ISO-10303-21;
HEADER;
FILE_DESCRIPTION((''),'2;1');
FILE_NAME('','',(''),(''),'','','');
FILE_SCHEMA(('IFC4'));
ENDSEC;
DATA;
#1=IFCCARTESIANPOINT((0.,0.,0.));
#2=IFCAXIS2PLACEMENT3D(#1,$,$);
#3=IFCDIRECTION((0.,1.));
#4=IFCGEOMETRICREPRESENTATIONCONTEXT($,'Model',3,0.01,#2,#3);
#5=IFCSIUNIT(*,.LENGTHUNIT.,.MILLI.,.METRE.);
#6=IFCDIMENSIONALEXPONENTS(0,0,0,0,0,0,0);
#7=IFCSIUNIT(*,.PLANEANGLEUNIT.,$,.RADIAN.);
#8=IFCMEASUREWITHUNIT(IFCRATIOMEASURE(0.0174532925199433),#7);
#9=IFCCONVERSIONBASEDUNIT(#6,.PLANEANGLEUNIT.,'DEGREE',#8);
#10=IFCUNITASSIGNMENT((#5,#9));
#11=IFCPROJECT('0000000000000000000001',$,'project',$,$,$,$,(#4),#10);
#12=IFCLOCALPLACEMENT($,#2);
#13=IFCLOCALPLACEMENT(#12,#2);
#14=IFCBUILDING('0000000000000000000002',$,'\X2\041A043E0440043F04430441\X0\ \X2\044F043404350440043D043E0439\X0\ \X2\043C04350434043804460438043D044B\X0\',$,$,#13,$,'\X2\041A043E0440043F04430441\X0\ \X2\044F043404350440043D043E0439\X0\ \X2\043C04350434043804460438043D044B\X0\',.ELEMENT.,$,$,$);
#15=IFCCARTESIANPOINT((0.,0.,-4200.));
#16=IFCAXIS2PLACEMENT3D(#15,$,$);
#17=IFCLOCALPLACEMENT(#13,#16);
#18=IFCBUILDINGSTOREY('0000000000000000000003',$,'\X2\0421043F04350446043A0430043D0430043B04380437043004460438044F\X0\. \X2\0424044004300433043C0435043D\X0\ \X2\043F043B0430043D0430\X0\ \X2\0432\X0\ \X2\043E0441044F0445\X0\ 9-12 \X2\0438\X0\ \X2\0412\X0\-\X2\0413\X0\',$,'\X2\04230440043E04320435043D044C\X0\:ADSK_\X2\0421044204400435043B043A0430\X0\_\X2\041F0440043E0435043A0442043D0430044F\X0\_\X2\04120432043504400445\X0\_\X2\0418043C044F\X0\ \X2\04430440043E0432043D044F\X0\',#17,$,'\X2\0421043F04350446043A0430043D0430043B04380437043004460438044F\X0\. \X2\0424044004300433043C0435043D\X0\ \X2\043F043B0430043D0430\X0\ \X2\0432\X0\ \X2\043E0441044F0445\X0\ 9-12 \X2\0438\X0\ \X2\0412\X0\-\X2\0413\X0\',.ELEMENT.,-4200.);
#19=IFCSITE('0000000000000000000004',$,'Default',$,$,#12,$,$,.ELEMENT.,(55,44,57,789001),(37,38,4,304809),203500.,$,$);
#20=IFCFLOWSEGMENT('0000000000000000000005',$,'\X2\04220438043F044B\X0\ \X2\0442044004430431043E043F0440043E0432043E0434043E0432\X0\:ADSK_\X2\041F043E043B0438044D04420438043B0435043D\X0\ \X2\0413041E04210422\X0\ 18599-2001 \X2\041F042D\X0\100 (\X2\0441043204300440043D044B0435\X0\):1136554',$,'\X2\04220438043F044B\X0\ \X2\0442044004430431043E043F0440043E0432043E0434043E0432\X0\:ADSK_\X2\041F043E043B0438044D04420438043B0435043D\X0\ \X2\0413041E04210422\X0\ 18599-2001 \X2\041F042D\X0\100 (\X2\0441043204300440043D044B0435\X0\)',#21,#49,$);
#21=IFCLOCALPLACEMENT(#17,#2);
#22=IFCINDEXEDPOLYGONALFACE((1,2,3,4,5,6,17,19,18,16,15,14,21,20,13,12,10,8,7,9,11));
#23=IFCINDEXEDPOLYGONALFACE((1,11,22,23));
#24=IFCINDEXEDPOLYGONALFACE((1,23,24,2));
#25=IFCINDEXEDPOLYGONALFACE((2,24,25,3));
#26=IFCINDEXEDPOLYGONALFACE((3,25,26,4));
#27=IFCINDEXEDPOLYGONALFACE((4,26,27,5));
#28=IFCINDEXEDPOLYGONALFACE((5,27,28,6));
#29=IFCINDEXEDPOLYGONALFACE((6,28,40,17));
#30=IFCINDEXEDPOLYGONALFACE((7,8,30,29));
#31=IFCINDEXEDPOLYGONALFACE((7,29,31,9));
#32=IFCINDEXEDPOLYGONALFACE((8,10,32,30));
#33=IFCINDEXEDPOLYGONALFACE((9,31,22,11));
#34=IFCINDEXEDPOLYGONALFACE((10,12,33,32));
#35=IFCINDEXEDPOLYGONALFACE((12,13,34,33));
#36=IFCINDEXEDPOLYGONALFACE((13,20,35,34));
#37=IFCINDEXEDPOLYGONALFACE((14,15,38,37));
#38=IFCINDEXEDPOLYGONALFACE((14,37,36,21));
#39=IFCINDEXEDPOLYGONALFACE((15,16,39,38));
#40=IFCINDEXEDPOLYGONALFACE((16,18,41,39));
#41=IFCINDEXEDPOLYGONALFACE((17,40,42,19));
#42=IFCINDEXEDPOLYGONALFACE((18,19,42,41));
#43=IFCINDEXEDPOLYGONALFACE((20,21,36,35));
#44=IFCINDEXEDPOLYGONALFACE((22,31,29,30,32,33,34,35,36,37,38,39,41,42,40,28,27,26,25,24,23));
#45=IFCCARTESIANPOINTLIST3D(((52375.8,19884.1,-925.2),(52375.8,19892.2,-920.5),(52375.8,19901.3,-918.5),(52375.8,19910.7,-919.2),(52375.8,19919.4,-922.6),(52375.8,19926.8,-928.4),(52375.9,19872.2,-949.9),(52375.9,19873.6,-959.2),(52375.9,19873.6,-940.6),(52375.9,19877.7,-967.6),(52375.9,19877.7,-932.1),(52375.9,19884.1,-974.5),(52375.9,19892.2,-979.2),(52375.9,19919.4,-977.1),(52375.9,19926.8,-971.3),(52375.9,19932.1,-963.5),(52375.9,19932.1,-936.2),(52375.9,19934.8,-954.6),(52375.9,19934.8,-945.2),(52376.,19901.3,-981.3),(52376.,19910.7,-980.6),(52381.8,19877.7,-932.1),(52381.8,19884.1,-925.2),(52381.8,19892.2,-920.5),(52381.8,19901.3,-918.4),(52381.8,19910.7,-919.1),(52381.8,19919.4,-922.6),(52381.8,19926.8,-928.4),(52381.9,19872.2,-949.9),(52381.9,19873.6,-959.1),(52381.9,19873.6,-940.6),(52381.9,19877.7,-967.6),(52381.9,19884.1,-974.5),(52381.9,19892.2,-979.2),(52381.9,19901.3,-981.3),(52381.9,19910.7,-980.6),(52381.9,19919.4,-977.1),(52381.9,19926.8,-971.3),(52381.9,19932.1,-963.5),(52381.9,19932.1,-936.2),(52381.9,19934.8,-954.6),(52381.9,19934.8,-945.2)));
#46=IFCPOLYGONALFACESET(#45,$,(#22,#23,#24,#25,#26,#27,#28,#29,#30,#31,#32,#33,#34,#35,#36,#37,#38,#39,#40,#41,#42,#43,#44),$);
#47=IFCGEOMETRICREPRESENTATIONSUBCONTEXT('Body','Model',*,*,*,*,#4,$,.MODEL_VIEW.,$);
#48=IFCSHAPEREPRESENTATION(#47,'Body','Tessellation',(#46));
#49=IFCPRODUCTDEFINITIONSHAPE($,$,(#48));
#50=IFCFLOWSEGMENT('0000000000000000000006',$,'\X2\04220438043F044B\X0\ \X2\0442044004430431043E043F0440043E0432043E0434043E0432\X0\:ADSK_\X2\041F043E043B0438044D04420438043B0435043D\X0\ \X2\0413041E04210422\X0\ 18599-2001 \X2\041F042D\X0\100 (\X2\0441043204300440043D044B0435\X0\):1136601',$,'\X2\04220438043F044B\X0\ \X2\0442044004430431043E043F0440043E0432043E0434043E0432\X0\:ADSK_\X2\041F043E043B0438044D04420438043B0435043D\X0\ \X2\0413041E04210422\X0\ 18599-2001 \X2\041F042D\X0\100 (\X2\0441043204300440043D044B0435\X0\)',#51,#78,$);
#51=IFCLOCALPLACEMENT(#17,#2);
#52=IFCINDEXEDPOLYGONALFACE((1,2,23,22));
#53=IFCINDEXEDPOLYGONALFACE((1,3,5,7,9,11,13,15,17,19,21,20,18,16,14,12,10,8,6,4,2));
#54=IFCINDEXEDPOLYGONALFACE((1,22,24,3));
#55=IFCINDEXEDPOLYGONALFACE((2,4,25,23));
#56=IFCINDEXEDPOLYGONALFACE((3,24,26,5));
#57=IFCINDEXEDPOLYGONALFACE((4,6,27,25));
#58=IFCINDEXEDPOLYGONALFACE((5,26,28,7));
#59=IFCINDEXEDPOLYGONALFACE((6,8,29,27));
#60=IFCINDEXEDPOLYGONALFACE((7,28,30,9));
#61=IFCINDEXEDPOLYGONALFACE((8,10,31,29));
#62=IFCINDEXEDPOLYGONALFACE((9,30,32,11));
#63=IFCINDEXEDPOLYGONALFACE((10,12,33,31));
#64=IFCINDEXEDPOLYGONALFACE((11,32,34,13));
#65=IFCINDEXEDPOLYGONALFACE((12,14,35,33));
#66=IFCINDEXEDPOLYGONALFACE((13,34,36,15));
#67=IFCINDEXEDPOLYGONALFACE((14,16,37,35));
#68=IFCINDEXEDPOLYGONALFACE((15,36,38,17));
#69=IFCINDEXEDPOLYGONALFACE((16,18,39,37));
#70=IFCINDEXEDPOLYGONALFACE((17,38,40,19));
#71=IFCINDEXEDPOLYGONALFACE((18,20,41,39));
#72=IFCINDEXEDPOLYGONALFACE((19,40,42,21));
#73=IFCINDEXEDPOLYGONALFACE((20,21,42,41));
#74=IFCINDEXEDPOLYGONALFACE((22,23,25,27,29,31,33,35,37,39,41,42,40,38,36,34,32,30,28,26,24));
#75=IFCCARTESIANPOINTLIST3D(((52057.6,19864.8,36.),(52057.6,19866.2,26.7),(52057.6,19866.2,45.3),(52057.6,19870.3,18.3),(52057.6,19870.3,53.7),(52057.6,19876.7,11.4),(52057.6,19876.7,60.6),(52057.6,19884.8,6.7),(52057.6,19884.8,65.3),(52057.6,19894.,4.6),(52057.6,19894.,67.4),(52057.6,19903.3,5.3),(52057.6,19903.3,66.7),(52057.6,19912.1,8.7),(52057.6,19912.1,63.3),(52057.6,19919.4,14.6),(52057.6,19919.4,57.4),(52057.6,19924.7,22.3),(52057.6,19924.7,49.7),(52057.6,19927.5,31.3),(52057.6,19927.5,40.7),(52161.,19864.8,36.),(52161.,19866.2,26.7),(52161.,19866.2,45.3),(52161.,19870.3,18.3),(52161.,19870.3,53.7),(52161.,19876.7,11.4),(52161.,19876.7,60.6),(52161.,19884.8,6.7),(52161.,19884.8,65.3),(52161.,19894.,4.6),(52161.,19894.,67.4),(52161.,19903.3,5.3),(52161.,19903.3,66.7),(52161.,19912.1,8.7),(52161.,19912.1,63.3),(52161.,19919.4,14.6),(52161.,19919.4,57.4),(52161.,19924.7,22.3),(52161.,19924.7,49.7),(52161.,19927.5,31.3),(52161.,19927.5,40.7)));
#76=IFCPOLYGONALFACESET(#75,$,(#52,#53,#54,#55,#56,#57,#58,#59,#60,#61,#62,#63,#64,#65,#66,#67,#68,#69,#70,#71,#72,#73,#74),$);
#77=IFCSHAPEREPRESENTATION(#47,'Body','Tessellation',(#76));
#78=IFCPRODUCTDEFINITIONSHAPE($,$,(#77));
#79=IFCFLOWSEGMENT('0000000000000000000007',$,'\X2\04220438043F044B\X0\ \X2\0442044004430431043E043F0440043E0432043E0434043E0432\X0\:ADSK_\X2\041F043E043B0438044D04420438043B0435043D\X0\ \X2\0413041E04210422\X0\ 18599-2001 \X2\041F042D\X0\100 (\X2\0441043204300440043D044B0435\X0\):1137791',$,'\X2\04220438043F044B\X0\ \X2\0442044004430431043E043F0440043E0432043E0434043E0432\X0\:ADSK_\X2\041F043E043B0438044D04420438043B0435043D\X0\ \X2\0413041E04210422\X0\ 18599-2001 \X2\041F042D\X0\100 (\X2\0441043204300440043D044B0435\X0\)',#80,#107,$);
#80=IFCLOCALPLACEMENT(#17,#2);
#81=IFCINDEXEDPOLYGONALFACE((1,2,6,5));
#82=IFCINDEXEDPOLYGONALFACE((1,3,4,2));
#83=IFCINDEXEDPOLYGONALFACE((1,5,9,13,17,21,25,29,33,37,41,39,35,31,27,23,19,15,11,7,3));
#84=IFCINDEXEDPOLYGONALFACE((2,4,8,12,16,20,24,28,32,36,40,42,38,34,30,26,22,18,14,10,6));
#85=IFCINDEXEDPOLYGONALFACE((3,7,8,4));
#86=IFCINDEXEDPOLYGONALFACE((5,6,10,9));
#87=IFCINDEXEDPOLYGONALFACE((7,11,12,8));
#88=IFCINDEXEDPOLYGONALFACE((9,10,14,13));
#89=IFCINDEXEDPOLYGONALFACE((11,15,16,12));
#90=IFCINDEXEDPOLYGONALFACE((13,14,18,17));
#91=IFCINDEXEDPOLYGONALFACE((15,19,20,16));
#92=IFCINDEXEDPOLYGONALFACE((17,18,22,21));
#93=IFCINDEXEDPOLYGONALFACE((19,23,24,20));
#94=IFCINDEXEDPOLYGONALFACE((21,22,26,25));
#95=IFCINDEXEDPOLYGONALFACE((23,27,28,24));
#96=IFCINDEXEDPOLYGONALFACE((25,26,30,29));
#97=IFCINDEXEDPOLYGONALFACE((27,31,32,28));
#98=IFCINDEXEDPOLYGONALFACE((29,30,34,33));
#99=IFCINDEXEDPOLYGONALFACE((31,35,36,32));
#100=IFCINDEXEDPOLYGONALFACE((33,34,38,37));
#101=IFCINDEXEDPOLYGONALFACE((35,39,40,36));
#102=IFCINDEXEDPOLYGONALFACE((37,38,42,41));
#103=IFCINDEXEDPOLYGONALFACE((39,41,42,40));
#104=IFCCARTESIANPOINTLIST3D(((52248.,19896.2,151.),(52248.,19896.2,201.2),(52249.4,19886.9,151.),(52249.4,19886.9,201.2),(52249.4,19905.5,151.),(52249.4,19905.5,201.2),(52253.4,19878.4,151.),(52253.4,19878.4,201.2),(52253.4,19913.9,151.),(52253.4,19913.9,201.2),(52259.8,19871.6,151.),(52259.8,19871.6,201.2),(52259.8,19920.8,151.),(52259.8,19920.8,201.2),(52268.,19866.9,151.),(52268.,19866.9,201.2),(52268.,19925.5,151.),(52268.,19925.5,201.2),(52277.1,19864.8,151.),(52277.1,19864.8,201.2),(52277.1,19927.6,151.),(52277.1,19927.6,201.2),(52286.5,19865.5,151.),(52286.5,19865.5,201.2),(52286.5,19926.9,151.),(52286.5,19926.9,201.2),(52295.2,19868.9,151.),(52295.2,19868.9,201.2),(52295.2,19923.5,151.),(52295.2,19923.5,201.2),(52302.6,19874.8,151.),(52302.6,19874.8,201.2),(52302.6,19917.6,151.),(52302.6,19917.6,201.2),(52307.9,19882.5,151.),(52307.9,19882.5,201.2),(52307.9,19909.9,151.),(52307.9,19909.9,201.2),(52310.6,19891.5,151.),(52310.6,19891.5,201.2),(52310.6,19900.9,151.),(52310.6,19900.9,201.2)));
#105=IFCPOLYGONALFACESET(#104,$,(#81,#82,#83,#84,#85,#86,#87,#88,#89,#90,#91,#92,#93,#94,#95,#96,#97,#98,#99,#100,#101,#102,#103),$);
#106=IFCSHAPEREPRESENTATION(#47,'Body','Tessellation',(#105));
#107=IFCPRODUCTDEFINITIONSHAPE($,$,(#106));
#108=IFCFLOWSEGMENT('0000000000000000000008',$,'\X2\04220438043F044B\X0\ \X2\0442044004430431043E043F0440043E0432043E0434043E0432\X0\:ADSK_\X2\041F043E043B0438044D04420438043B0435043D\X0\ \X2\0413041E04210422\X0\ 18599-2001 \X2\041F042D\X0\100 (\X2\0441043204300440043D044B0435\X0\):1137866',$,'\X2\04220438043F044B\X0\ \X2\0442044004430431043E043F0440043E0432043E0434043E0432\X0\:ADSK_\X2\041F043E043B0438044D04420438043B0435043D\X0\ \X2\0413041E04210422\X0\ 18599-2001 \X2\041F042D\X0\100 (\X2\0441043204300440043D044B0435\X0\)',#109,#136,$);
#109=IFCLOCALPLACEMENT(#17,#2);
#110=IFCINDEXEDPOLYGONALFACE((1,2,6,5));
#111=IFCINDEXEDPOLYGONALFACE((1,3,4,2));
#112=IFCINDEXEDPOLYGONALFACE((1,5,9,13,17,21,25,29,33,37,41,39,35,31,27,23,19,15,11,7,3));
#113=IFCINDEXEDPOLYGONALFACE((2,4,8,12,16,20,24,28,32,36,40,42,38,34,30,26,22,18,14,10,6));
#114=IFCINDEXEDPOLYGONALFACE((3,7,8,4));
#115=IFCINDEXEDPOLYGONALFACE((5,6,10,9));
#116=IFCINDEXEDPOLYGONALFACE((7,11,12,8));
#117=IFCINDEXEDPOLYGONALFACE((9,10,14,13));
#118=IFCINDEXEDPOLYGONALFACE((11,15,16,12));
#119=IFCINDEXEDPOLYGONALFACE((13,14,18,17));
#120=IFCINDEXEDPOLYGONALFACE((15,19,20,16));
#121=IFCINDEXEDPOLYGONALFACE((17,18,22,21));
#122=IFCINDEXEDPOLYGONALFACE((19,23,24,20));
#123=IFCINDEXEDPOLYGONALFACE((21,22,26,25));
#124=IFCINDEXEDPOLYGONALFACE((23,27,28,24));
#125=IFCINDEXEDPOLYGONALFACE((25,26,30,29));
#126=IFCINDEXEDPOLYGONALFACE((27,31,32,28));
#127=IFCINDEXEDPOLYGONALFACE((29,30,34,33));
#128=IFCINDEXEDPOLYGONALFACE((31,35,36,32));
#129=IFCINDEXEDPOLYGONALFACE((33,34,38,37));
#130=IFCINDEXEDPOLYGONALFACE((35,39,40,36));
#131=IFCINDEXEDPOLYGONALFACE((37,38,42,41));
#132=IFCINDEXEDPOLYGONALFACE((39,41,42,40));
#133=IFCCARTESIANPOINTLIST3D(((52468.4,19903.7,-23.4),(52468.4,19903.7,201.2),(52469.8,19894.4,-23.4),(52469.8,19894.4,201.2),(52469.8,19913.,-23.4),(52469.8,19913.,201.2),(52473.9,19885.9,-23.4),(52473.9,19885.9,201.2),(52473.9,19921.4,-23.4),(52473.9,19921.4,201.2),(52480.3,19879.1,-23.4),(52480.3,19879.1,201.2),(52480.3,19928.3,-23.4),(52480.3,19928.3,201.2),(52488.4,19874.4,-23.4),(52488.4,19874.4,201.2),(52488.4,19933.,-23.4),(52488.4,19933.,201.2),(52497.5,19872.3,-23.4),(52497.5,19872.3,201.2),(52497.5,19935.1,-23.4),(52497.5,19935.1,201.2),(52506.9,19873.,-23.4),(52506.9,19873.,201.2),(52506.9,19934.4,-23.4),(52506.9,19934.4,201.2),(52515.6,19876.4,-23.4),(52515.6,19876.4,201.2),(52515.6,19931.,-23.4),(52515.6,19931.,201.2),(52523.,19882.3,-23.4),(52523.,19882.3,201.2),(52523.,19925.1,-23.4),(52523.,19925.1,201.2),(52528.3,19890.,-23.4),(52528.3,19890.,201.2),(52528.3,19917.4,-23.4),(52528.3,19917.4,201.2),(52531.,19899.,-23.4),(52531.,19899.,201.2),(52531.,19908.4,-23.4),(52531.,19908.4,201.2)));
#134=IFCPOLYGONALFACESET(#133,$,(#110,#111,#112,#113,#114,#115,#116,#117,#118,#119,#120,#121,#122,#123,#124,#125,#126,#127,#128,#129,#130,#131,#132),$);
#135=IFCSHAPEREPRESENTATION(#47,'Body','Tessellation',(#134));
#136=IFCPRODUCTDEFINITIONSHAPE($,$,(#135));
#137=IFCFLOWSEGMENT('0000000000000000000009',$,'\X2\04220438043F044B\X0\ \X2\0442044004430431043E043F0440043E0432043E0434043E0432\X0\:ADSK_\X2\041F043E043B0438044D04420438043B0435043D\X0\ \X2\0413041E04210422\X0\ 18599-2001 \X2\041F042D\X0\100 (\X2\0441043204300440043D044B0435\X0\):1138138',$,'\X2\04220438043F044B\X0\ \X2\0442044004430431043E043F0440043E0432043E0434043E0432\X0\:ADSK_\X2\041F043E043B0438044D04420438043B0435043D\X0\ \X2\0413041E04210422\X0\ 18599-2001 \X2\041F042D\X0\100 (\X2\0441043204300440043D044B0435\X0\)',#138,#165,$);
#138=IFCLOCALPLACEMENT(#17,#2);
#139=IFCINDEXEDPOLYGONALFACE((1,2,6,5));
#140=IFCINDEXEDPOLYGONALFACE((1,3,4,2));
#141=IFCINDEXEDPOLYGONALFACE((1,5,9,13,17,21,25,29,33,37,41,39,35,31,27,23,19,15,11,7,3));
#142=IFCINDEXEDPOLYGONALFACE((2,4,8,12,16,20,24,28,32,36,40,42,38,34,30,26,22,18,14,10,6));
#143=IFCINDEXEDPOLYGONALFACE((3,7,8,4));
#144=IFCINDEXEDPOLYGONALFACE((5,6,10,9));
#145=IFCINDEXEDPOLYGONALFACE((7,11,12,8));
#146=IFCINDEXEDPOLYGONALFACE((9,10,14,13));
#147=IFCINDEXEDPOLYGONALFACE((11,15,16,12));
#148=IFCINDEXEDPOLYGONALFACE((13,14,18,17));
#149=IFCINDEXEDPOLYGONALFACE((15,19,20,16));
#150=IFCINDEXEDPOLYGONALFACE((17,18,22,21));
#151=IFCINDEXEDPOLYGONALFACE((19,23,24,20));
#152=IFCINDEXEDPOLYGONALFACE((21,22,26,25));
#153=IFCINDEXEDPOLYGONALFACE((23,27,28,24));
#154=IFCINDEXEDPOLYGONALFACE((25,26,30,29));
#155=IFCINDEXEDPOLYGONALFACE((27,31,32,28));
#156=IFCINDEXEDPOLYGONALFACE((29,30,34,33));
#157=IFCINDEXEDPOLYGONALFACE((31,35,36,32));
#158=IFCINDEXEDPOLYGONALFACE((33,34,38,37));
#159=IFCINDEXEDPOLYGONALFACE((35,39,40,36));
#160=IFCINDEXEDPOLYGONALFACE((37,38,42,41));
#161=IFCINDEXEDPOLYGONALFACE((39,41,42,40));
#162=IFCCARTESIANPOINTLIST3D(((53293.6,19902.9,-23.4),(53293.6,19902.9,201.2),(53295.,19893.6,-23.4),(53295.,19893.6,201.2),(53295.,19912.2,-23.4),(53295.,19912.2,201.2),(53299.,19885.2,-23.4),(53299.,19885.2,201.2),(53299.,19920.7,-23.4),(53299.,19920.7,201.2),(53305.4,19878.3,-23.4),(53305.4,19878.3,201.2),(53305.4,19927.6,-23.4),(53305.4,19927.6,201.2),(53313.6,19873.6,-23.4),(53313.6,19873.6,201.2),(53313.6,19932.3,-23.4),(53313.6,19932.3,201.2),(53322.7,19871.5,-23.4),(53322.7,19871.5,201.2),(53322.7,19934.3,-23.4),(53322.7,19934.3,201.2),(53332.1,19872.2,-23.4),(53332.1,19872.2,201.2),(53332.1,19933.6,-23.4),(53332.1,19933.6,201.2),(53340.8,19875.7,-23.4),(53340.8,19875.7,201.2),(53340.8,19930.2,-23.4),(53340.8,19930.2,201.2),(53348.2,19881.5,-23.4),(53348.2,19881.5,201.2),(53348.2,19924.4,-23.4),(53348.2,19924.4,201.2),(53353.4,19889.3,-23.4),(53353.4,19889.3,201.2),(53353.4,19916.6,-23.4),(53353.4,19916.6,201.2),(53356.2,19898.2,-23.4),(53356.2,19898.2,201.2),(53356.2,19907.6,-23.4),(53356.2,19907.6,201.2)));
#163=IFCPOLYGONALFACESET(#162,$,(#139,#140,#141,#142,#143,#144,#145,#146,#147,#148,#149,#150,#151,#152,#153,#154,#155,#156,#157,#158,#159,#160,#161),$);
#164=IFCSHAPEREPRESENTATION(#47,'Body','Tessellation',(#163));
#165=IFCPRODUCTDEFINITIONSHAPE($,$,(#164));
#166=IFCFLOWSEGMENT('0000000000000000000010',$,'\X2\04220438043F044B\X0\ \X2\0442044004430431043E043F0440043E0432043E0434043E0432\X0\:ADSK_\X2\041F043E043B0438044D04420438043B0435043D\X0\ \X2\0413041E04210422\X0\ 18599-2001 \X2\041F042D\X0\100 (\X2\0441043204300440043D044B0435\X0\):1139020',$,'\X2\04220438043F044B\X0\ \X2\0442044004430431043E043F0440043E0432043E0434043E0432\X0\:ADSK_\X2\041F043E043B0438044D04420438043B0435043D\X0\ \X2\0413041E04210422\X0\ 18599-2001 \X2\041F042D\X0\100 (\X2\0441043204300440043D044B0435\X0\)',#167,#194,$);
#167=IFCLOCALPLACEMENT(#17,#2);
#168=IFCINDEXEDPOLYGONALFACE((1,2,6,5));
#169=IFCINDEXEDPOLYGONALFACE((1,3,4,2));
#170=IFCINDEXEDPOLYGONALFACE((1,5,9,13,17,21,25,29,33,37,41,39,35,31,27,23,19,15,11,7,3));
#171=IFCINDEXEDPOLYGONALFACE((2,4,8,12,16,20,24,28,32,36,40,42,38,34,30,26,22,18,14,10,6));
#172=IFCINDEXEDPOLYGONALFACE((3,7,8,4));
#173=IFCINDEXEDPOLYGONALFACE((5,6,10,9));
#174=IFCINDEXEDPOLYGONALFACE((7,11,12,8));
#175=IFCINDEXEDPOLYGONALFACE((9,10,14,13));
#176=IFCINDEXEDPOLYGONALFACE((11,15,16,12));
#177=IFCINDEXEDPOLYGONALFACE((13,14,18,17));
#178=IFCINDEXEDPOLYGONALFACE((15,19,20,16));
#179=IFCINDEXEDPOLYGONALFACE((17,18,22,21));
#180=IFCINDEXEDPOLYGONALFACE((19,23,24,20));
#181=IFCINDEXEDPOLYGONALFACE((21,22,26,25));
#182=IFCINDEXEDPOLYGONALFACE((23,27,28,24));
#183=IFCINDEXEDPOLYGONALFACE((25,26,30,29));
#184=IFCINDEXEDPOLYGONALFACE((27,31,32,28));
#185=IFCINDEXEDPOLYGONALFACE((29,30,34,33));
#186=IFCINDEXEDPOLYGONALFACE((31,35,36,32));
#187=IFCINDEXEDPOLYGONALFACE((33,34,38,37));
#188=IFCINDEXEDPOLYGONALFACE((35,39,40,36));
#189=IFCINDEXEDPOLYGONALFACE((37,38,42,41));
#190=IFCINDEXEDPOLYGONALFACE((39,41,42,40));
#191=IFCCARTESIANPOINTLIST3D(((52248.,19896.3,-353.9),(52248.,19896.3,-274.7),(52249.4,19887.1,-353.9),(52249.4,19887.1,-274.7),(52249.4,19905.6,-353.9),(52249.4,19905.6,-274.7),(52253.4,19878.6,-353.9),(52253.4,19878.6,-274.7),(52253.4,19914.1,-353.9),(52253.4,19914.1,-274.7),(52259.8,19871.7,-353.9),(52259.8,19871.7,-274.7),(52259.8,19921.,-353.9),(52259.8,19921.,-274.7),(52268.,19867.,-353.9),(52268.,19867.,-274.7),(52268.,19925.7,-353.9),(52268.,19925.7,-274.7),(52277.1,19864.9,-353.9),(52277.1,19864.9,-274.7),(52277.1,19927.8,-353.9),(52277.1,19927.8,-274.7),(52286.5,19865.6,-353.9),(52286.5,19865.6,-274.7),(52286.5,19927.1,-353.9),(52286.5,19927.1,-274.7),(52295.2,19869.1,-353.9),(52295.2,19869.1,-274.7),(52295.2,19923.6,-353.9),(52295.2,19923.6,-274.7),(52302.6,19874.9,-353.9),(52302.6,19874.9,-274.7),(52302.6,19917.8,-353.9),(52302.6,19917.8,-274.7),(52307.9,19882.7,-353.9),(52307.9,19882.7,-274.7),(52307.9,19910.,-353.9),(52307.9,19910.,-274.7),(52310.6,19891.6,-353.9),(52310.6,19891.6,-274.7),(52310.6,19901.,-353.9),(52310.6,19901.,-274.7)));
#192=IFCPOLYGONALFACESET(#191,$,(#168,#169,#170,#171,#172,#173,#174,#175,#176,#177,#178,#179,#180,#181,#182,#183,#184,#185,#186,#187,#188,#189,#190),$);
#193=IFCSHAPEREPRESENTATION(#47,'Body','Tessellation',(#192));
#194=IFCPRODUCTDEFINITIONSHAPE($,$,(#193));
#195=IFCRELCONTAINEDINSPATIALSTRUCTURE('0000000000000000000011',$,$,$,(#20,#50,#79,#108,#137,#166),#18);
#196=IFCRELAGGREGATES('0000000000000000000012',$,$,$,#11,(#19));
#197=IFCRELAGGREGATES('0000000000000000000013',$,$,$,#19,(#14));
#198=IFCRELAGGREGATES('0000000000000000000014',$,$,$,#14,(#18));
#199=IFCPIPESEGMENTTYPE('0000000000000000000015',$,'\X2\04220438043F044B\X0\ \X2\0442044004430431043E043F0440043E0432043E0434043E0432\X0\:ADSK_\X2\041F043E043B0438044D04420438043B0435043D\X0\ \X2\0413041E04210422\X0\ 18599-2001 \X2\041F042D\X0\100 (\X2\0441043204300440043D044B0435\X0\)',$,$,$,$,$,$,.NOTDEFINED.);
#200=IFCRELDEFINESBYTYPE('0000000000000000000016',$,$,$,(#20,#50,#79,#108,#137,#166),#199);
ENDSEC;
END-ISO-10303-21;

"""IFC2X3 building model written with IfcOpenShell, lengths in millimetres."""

from ifc_helpers import new_model, entity, si_unit, converted_unit, direction, frame, origin, origin_2d_with_axis, place, context, subcontext, project, spatial, circle, extrude, type_object, element, save


model = new_model("IFC2X3")

# Units and contexts
model_context = context("Model", 3, precision=0.01, world=origin(), true_north=direction((0.0, 1.0)))
body_context = subcontext(model_context, "Body", "Model", "MODEL_VIEW")
ifc_project = project(units=[si_unit("LENGTHUNIT", "METRE", prefix="MILLI"), converted_unit("PLANEANGLEUNIT", "DEGREE", entity("IfcRatioMeasure", 0.0174532925199433), si_unit("PLANEANGLEUNIT", "RADIAN"), dimensions=[0, 0, 0, 0, 0, 0, 0])], contexts=[model_context])

# Site, building, storey
site_placement = place(None, origin())
site = spatial("IfcSite", under=ifc_project, at=site_placement, Name="Default", CompositionType="ELEMENT", RefLatitude=(55, 44, 57, 789001), RefLongitude=(37, 38, 4, 304809), RefElevation=203500.0)
building_placement = place(site_placement, origin())
building = spatial("IfcBuilding", under=site, at=building_placement, Name="Корпус ядерной медицины", LongName="Корпус ядерной медицины", CompositionType="ELEMENT")
storey_placement = place(building_placement, frame((0.0, 0.0, -4200.0)))
storey = spatial("IfcBuildingStorey", under=building, at=storey_placement, Name="Спецканализация. Фрагмен плана в осях 9-12 и В-Г", ObjectType="Уровень:ADSK_Стрелка_Проектная_Вверх_Имя уровня", LongName="Спецканализация. Фрагмен плана в осях 9-12 и В-Г", CompositionType="ELEMENT", Elevation=-4200.0)

# Flow segments
pipe_segment_type = type_object("IfcPipeSegmentType", Name="Типы трубопроводов:ADSK_Полиэтилен ГОСТ 18599-2001 ПЭ100 (сварные)", PredefinedType="NOTDEFINED")
flow_segment_1_placement = place(storey_placement, frame((52375.8, 19870.6, -983.0)))
element("IfcFlowSegment", 1, at=flow_segment_1_placement, inside=storey, type_object=pipe_segment_type, Name="Типы трубопроводов:ADSK_Полиэтилен ГОСТ 18599-2001 ПЭ100 (сварные):1136554", ObjectType="Типы трубопроводов:ADSK_Полиэтилен ГОСТ 18599-2001 ПЭ100 (сварные)", context=body_context, shape_type="SweptSolid", body=[
    extrude(circle(Radius=31.5, at=origin_2d_with_axis()), frame((0.1, 33.1, 33.1), z_axis=(0.999998, 0.0, 0.002), x_axis=(0.0, -1.0, 0.0)), (0.0, 0.0, 1.0), 6.0),
])
flow_segment_2_placement = place(storey_placement, frame((52057.6, 19863.2, 2.9)))
element("IfcFlowSegment", 2, at=flow_segment_2_placement, inside=storey, type_object=pipe_segment_type, Name="Типы трубопроводов:ADSK_Полиэтилен ГОСТ 18599-2001 ПЭ100 (сварные):1136601", ObjectType="Типы трубопроводов:ADSK_Полиэтилен ГОСТ 18599-2001 ПЭ100 (сварные)", context=body_context, shape_type="SweptSolid", body=[
    extrude(circle(Radius=31.5, at=origin_2d_with_axis()), frame((0.0, 33.1, 33.1), z_axis=(1.0, 0.0, 0.0), x_axis=(0.0, -1.0, 0.0)), (0.0, 0.0, 1.0), 103.4),
])
flow_segment_3_placement = place(storey_placement, frame((52246.4, 19863.1, 151.0)))
element("IfcFlowSegment", 3, at=flow_segment_3_placement, inside=storey, type_object=pipe_segment_type, Name="Типы трубопроводов:ADSK_Полиэтилен ГОСТ 18599-2001 ПЭ100 (сварные):1137791", ObjectType="Типы трубопроводов:ADSK_Полиэтилен ГОСТ 18599-2001 ПЭ100 (сварные)", context=body_context, shape_type="SweptSolid", body=[
    extrude(circle(Radius=31.5, at=origin_2d_with_axis()), frame((33.1, 33.1, 0.0), z_axis=(-0.000008, 0.0, 1.0), x_axis=(-1.0, 0.0, -0.000008)), (0.0, 0.0, 1.0), 50.2),
])
flow_segment_4_placement = place(storey_placement, frame((52466.8, 19870.6, -23.4)))
element("IfcFlowSegment", 4, at=flow_segment_4_placement, inside=storey, type_object=pipe_segment_type, Name="Типы трубопроводов:ADSK_Полиэтилен ГОСТ 18599-2001 ПЭ100 (сварные):1137866", ObjectType="Типы трубопроводов:ADSK_Полиэтилен ГОСТ 18599-2001 ПЭ100 (сварные)", context=body_context, shape_type="SweptSolid", body=[
    extrude(circle(Radius=31.5, at=origin_2d_with_axis()), frame((33.1, 33.1, 0.0), z_axis=(0.000001, 0.0, 1.0), x_axis=(-1.0, 0.0, 0.000001)), (0.0, 0.0, 1.0), 224.7),
])
flow_segment_5_placement = place(storey_placement, frame((53292.0, 19869.8, -23.4)))
element("IfcFlowSegment", 5, at=flow_segment_5_placement, inside=storey, type_object=pipe_segment_type, Name="Типы трубопроводов:ADSK_Полиэтилен ГОСТ 18599-2001 ПЭ100 (сварные):1138138", ObjectType="Типы трубопроводов:ADSK_Полиэтилен ГОСТ 18599-2001 ПЭ100 (сварные)", context=body_context, shape_type="SweptSolid", body=[
    extrude(circle(Radius=31.5, at=origin_2d_with_axis()), frame((33.1, 33.1, 0.0), z_axis=(0.000002, 0.0, 1.0), x_axis=(-1.0, 0.0, 0.000002)), (0.0, 0.0, 1.0), 224.7),
])
flow_segment_6_placement = place(storey_placement, frame((52246.4, 19863.2, -353.9)))
element("IfcFlowSegment", 6, at=flow_segment_6_placement, inside=storey, type_object=pipe_segment_type, Name="Типы трубопроводов:ADSK_Полиэтилен ГОСТ 18599-2001 ПЭ100 (сварные):1139020", ObjectType="Типы трубопроводов:ADSK_Полиэтилен ГОСТ 18599-2001 ПЭ100 (сварные)", context=body_context, shape_type="SweptSolid", body=[
    extrude(circle(Radius=31.5, at=origin_2d_with_axis()), frame((33.1, 33.1, 0.0), z_axis=(0.000001, 0.0, 1.0), x_axis=(-1.0, 0.0, 0.000001)), (0.0, 0.0, 1.0), 79.1),
])

save(model, "model.ifc")
